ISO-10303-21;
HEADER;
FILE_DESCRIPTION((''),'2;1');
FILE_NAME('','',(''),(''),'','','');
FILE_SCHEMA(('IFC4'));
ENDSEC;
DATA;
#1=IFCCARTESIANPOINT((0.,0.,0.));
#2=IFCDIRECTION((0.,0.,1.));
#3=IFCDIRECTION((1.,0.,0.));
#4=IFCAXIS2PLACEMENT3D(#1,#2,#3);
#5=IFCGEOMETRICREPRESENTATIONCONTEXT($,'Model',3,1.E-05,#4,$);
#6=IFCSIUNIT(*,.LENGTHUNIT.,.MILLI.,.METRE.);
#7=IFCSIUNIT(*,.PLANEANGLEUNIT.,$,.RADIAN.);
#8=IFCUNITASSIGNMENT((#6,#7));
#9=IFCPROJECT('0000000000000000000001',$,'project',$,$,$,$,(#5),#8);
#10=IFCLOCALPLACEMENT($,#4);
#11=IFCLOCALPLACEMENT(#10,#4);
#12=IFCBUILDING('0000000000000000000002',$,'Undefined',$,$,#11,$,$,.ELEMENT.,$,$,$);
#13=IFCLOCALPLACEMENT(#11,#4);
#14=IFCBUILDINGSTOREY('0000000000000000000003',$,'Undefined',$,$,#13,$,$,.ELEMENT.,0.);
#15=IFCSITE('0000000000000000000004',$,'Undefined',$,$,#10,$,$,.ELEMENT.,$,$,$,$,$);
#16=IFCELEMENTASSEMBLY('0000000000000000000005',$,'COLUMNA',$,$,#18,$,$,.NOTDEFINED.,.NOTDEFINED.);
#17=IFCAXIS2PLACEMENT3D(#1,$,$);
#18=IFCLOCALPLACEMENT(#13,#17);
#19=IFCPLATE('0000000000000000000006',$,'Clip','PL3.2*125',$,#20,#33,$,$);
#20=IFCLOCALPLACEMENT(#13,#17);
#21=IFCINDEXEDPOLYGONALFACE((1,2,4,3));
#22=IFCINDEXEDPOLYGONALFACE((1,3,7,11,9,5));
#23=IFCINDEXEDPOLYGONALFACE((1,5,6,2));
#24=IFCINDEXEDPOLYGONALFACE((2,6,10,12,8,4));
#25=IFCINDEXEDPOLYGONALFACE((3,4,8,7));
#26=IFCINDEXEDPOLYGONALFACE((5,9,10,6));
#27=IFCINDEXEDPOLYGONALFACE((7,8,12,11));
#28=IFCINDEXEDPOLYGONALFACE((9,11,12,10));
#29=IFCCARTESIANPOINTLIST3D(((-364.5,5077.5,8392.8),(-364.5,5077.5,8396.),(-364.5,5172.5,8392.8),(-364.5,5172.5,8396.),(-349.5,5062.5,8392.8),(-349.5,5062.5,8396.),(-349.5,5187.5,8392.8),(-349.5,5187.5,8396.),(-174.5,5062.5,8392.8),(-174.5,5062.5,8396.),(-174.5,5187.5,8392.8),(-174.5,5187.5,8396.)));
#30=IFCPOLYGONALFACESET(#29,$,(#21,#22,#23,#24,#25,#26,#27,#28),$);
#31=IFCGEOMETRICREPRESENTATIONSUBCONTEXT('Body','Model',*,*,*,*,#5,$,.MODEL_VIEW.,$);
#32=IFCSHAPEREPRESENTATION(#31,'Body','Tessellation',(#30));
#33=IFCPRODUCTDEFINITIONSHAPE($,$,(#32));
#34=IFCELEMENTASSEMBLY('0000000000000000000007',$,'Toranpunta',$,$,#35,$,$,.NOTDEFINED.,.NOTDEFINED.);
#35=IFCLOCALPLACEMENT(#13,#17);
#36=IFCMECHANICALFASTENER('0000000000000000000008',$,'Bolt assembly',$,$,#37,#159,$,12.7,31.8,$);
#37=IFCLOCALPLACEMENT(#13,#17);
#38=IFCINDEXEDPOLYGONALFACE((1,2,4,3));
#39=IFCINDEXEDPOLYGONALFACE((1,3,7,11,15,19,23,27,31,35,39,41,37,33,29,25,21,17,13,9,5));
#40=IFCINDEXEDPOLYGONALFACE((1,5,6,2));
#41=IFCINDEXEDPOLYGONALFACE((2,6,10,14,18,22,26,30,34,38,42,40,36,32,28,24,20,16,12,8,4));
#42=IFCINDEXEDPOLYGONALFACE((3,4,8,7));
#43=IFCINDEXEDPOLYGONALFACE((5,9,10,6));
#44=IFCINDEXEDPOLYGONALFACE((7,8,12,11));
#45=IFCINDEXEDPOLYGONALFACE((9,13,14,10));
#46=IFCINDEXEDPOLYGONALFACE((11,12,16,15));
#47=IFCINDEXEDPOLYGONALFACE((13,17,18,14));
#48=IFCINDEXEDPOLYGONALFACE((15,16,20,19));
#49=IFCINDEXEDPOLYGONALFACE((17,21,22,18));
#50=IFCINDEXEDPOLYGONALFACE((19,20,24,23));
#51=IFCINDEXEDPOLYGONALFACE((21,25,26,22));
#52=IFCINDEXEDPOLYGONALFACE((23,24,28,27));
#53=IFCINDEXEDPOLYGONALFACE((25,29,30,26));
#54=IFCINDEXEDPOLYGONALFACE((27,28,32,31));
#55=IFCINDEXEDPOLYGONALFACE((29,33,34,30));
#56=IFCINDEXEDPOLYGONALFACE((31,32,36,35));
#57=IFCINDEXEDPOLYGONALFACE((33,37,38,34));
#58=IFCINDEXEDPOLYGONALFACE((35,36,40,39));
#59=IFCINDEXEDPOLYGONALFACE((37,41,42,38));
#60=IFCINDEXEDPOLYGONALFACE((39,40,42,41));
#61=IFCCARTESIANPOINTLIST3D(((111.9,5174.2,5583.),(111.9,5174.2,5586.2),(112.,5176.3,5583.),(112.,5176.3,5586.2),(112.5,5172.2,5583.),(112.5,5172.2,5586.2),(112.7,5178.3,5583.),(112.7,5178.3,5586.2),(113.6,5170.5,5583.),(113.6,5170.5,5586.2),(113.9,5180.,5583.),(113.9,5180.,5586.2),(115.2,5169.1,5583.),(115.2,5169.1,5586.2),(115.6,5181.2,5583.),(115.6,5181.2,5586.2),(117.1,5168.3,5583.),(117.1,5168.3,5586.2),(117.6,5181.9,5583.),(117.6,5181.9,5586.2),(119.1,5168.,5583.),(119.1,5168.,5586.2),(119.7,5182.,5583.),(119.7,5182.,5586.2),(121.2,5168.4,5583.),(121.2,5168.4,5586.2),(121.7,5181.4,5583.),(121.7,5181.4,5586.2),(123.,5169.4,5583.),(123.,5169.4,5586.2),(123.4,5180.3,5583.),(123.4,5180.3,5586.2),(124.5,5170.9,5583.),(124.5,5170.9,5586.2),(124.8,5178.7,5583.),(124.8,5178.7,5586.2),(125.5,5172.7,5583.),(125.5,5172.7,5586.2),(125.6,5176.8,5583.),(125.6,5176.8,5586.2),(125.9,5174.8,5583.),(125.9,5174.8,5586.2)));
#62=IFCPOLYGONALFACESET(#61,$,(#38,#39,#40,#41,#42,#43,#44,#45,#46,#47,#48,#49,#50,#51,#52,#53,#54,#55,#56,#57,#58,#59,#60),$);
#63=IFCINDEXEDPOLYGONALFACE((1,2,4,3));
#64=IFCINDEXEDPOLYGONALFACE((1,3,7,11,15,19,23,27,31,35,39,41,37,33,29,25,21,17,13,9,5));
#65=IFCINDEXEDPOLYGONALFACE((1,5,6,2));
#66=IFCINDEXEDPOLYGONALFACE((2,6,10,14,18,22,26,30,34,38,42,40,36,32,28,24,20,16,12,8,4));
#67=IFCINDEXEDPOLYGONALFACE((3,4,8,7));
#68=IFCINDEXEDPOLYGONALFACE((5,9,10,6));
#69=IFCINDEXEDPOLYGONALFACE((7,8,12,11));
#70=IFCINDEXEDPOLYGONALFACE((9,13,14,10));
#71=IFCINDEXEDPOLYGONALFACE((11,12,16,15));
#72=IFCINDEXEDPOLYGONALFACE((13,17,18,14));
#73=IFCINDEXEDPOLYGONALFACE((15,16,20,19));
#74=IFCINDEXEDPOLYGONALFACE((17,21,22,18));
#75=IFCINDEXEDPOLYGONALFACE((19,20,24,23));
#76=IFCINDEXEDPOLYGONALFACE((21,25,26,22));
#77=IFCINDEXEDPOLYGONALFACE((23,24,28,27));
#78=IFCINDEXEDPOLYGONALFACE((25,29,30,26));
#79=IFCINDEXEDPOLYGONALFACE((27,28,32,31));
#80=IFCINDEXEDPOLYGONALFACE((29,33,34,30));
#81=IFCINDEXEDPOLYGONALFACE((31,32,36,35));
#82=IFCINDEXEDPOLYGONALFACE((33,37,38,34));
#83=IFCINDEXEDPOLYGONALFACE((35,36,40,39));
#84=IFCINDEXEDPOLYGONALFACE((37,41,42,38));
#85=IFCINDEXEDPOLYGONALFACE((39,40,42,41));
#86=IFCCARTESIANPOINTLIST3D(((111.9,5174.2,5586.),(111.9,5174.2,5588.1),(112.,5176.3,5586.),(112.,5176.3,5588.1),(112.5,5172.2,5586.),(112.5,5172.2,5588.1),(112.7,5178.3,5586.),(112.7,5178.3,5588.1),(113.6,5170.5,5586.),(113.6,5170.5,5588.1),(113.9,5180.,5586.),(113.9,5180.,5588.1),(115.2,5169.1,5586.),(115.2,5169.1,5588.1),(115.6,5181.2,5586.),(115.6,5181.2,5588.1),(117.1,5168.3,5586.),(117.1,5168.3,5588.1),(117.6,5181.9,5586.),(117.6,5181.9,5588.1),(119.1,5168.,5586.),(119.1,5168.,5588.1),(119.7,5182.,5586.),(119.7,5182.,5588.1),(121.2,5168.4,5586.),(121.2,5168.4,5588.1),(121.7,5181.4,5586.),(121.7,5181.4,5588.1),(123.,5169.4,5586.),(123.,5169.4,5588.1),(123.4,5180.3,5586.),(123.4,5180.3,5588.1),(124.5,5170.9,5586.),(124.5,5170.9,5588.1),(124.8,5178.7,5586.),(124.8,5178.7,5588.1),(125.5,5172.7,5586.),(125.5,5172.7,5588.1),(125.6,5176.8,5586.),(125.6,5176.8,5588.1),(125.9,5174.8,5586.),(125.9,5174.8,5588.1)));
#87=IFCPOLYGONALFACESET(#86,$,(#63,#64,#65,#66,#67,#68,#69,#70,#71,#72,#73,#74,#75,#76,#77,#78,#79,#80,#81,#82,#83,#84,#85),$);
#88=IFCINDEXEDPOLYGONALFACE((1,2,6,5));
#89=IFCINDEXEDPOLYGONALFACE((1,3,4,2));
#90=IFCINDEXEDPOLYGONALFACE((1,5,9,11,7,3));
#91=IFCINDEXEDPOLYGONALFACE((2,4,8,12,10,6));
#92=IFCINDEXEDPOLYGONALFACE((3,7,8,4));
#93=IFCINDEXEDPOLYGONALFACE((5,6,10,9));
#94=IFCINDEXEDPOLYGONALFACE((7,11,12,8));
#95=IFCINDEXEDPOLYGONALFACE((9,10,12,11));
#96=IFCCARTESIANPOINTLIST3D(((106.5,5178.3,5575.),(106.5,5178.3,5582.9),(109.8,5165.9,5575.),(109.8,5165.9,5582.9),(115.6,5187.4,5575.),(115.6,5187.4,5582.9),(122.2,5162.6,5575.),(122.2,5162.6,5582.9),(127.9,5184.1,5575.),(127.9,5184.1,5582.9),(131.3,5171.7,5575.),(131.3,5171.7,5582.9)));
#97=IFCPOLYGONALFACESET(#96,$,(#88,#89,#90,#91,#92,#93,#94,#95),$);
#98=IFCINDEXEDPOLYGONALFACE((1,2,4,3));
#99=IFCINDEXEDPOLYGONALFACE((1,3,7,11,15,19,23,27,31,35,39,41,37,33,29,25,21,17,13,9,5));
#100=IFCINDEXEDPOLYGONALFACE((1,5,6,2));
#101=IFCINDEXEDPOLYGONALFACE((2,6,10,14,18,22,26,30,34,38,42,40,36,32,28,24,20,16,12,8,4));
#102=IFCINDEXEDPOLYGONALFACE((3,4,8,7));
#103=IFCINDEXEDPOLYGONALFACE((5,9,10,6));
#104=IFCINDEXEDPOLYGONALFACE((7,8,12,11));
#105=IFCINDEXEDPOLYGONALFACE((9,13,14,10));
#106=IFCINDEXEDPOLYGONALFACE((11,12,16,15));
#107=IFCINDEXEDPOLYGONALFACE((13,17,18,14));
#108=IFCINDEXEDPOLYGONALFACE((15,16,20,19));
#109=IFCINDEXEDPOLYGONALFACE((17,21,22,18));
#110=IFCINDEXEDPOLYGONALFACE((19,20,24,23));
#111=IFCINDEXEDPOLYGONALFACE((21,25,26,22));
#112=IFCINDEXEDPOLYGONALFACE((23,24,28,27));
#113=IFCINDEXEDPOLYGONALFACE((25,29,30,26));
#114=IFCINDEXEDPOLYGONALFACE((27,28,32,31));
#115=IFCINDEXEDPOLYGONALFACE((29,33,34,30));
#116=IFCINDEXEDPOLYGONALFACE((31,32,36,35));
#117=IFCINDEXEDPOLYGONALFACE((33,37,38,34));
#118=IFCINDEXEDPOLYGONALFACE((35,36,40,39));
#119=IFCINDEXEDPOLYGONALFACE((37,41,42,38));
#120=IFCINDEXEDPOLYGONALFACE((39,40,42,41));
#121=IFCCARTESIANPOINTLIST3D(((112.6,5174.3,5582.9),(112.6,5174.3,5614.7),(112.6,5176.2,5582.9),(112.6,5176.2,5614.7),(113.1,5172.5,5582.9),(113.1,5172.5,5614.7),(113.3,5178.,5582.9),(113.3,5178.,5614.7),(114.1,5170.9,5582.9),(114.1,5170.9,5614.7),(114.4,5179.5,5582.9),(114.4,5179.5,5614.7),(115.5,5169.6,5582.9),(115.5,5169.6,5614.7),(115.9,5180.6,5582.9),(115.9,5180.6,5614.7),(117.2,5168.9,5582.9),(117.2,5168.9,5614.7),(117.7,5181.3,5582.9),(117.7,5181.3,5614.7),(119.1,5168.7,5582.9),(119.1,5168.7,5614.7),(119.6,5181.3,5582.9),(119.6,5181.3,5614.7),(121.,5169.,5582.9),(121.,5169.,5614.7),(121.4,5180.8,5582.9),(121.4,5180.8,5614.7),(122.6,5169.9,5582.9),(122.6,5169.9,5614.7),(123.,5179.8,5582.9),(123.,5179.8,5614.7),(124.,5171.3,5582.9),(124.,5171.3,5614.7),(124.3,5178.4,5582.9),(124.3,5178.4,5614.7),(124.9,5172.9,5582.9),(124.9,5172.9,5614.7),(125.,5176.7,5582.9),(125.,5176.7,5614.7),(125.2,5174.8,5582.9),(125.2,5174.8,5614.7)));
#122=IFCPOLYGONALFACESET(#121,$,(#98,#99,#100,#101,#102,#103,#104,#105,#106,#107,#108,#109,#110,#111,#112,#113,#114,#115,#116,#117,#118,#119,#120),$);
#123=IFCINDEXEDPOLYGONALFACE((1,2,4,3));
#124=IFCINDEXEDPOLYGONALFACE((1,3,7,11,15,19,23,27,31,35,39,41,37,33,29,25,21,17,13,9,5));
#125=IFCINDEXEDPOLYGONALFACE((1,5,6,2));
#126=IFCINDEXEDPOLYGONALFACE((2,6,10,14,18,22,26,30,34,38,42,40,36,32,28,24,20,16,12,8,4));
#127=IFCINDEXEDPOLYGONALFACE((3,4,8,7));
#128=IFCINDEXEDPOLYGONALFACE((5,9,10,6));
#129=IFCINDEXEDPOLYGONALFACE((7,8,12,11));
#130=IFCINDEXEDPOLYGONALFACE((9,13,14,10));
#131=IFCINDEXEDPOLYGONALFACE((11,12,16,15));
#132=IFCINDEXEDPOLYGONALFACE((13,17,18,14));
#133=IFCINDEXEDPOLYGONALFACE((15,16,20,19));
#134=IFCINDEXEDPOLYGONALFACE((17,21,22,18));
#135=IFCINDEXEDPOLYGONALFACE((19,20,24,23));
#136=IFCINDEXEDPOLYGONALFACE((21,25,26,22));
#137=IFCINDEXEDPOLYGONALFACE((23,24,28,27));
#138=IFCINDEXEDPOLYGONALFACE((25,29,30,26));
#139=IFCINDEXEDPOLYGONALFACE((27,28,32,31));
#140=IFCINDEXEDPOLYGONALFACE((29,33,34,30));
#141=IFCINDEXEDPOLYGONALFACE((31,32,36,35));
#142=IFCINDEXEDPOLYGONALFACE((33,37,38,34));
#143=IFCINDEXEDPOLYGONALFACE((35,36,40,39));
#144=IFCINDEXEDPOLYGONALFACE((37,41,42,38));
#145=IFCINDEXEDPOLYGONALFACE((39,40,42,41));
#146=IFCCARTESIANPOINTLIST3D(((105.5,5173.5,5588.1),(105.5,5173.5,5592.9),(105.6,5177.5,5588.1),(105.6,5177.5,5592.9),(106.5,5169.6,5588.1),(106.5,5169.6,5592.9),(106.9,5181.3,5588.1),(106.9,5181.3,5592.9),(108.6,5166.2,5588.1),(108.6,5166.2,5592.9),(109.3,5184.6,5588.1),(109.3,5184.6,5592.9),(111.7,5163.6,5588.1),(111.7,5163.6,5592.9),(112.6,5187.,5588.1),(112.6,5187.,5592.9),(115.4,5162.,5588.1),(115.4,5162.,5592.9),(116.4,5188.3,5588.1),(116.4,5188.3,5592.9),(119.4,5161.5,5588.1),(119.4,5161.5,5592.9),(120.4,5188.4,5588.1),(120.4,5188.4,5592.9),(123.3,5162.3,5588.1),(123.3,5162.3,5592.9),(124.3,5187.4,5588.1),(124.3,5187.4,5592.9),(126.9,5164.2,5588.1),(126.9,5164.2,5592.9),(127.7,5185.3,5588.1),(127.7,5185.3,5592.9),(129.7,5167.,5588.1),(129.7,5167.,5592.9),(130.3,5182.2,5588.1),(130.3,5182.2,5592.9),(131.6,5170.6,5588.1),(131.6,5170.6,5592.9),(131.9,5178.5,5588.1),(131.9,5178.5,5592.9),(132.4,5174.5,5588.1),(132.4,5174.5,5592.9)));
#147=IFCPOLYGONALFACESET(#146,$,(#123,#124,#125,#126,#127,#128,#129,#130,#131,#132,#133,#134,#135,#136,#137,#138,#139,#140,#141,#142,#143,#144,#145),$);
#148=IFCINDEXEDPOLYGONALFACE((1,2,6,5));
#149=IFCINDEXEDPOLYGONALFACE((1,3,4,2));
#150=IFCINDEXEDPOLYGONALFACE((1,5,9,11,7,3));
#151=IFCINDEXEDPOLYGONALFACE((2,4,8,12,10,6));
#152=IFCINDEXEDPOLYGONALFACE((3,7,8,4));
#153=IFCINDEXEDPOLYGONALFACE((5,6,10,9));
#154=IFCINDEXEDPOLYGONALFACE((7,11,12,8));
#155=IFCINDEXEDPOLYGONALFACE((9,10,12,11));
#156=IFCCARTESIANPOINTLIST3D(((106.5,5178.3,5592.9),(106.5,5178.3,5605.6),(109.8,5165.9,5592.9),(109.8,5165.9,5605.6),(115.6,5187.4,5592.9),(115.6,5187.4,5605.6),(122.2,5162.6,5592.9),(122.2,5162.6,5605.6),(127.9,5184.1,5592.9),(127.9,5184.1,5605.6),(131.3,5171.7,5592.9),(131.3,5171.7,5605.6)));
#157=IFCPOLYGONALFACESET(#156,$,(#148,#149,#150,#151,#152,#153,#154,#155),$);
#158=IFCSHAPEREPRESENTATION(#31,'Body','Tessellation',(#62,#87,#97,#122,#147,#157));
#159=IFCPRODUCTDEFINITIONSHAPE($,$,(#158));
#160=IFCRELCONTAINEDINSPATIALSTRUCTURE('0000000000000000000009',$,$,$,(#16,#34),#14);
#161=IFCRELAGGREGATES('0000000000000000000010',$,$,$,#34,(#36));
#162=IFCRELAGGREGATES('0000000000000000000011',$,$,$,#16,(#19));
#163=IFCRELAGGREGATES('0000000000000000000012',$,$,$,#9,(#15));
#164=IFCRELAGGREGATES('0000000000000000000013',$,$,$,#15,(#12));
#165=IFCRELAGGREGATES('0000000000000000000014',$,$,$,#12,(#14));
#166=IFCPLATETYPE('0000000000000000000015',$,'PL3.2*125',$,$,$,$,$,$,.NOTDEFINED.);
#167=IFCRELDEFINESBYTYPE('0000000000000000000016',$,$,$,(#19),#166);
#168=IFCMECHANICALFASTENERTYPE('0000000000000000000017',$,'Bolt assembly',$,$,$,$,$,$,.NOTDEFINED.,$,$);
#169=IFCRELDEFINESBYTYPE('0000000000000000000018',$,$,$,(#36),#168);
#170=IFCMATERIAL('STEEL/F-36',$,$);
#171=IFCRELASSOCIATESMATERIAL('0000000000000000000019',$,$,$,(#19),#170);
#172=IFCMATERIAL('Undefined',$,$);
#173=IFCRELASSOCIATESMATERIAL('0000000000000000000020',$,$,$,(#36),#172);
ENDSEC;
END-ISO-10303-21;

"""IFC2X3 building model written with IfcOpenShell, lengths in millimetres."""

from ifc_helpers import new_model, si_unit, frame, origin_with_axes, origin_2d_with_axis, place, context, subcontext, project, spatial, polyline, circle, outline, extrude, source, transform, mapped, material, type_object, element, aggregate, save


model = new_model("IFC2X3")

# Units and contexts
model_context = context("Model", 3, precision=1e-05, world=origin_with_axes())
body_context = subcontext(model_context, "Body", "Model", "MODEL_VIEW")
ifc_project = project(units=[si_unit("LENGTHUNIT", "METRE", prefix="MILLI"), si_unit("PLANEANGLEUNIT", "RADIAN")], contexts=[model_context])

# Site, building, storey
site_placement = place(None, origin_with_axes())
site = spatial("IfcSite", under=ifc_project, at=site_placement, Name="Undefined", CompositionType="ELEMENT")
building_placement = place(site_placement, origin_with_axes())
building = spatial("IfcBuilding", under=site, at=building_placement, Name="Undefined", CompositionType="ELEMENT")
storey_placement = place(building_placement, origin_with_axes())
storey = spatial("IfcBuildingStorey", under=building, at=storey_placement, Name="Undefined", CompositionType="ELEMENT", Elevation=0.0)

# Element assembly, plate
assembly_1_placement = place(storey_placement, origin_with_axes())
assembly_1 = element("IfcElementAssembly", 1, at=assembly_1_placement, inside=storey, Name="COLUMNA", AssemblyPlace="NOTDEFINED", PredefinedType="NOTDEFINED")
ifc_material_1 = material(Name="STEEL/F-36")
plate_type_1 = type_object("IfcPlateType", Name="PL3.2*125", PredefinedType="NOTDEFINED")
plate_1_placement = place(assembly_1_placement, frame((-174.5, 5187.5, 8394.4), z_axis=(0.000007, 0.0, -1.0), x_axis=(0.0, -1.0, 0.0)))
plate_1 = element("IfcPlate", 2, at=plate_1_placement, type_object=plate_type_1, material=ifc_material_1, Name="Clip", Description="PL3.2*125", context=body_context, shape_type="SweptSolid", body=[
    extrude(outline(polyline([(0.0, 0.0), (125.0, 0.0), (125.0, 175.0), (110.0, 190.0), (15.0, 190.0), (0.0, 175.0), (0.0, 0.0)])), frame((0.0, 0.0, -1.6), z_axis=(0.0, 0.0, 1.0), x_axis=(1.0, 0.0, 0.0)), (0.0, 0.0, 1.0), 3.2),
])

# Element assembly, mechanical fastener
assembly_2_placement = place(storey_placement, origin_with_axes())
assembly_2 = element("IfcElementAssembly", 3, at=assembly_2_placement, inside=storey, Name="Toranpunta", AssemblyPlace="NOTDEFINED", PredefinedType="NOTDEFINED")
ifc_material_2 = material(Name="Undefined")
mechanical_fastener_type = type_object("IfcMechanicalFastenerType", Name="Bolt assembly")
shared_shape_1 = source(origin_with_axes(), body_context, "Body", "SweptSolid", [
    extrude(circle(Radius=7.0, at=origin_2d_with_axis()), frame((0.0, 0.1, 0.0), z_axis=(0.0, 1.0, 0.0), x_axis=(1.0, 0.0, 0.0)), (0.0, 0.0, 1.0), 3.2),
    extrude(circle(Radius=7.0, at=origin_2d_with_axis()), frame((0.0, 3.1, 0.0), z_axis=(0.0, 1.0, 0.0), x_axis=(1.0, 0.0, 0.0)), (0.0, 0.0, 1.0), 2.1),
    extrude(outline(polyline([(11.1, -6.4), (11.1, 6.4), (0.0, 12.8), (-11.1, 6.4), (-11.1, -6.4), (0.0, -12.8), (11.1, -6.4)])), frame((0.0, -7.9, 0.0), z_axis=(0.0, 1.0, 0.0), x_axis=(1.0, 0.0, 0.0)), (0.0, 0.0, 1.0), 7.9),
    extrude(circle(Radius=6.3, at=origin_2d_with_axis()), frame((0.0, 0.0, 0.0), z_axis=(0.0, 1.0, 0.0), x_axis=(1.0, 0.0, 0.0)), (0.0, 0.0, 1.0), 31.8),
    extrude(circle(Radius=13.5, at=origin_2d_with_axis()), frame((0.0, 5.2, 0.0), z_axis=(0.0, 1.0, 0.0), x_axis=(1.0, 0.0, 0.0)), (0.0, 0.0, 1.0), 4.8),
    extrude(outline(polyline([(11.1, -6.4), (11.1, 6.4), (0.0, 12.8), (-11.1, 6.4), (-11.1, -6.4), (0.0, -12.8), (11.1, -6.4)])), frame((0.0, 10.0, 0.0), z_axis=(0.0, 1.0, 0.0), x_axis=(1.0, 0.0, 0.0)), (0.0, 0.0, 1.0), 12.7),
])
mechanical_fastener_1_placement = place(assembly_2_placement, frame((118.9, 5175.0, 5582.9), z_axis=(0.707107, 0.707107, -0.000005), x_axis=(-0.707107, 0.707106, 0.000005)))
mechanical_fastener_1 = element("IfcMechanicalFastener", 4, at=mechanical_fastener_1_placement, type_object=mechanical_fastener_type, material=ifc_material_2, Name="Bolt assembly", NominalDiameter=12.7, NominalLength=31.8, context=body_context, shape_type="MappedRepresentation", body=[
    mapped(shared_shape_1, transform((0.0, 0.0, 0.0))),
])
aggregate(assembly_2, [mechanical_fastener_1])

aggregate(assembly_1, [plate_1])

save(model, "model.ifc")
